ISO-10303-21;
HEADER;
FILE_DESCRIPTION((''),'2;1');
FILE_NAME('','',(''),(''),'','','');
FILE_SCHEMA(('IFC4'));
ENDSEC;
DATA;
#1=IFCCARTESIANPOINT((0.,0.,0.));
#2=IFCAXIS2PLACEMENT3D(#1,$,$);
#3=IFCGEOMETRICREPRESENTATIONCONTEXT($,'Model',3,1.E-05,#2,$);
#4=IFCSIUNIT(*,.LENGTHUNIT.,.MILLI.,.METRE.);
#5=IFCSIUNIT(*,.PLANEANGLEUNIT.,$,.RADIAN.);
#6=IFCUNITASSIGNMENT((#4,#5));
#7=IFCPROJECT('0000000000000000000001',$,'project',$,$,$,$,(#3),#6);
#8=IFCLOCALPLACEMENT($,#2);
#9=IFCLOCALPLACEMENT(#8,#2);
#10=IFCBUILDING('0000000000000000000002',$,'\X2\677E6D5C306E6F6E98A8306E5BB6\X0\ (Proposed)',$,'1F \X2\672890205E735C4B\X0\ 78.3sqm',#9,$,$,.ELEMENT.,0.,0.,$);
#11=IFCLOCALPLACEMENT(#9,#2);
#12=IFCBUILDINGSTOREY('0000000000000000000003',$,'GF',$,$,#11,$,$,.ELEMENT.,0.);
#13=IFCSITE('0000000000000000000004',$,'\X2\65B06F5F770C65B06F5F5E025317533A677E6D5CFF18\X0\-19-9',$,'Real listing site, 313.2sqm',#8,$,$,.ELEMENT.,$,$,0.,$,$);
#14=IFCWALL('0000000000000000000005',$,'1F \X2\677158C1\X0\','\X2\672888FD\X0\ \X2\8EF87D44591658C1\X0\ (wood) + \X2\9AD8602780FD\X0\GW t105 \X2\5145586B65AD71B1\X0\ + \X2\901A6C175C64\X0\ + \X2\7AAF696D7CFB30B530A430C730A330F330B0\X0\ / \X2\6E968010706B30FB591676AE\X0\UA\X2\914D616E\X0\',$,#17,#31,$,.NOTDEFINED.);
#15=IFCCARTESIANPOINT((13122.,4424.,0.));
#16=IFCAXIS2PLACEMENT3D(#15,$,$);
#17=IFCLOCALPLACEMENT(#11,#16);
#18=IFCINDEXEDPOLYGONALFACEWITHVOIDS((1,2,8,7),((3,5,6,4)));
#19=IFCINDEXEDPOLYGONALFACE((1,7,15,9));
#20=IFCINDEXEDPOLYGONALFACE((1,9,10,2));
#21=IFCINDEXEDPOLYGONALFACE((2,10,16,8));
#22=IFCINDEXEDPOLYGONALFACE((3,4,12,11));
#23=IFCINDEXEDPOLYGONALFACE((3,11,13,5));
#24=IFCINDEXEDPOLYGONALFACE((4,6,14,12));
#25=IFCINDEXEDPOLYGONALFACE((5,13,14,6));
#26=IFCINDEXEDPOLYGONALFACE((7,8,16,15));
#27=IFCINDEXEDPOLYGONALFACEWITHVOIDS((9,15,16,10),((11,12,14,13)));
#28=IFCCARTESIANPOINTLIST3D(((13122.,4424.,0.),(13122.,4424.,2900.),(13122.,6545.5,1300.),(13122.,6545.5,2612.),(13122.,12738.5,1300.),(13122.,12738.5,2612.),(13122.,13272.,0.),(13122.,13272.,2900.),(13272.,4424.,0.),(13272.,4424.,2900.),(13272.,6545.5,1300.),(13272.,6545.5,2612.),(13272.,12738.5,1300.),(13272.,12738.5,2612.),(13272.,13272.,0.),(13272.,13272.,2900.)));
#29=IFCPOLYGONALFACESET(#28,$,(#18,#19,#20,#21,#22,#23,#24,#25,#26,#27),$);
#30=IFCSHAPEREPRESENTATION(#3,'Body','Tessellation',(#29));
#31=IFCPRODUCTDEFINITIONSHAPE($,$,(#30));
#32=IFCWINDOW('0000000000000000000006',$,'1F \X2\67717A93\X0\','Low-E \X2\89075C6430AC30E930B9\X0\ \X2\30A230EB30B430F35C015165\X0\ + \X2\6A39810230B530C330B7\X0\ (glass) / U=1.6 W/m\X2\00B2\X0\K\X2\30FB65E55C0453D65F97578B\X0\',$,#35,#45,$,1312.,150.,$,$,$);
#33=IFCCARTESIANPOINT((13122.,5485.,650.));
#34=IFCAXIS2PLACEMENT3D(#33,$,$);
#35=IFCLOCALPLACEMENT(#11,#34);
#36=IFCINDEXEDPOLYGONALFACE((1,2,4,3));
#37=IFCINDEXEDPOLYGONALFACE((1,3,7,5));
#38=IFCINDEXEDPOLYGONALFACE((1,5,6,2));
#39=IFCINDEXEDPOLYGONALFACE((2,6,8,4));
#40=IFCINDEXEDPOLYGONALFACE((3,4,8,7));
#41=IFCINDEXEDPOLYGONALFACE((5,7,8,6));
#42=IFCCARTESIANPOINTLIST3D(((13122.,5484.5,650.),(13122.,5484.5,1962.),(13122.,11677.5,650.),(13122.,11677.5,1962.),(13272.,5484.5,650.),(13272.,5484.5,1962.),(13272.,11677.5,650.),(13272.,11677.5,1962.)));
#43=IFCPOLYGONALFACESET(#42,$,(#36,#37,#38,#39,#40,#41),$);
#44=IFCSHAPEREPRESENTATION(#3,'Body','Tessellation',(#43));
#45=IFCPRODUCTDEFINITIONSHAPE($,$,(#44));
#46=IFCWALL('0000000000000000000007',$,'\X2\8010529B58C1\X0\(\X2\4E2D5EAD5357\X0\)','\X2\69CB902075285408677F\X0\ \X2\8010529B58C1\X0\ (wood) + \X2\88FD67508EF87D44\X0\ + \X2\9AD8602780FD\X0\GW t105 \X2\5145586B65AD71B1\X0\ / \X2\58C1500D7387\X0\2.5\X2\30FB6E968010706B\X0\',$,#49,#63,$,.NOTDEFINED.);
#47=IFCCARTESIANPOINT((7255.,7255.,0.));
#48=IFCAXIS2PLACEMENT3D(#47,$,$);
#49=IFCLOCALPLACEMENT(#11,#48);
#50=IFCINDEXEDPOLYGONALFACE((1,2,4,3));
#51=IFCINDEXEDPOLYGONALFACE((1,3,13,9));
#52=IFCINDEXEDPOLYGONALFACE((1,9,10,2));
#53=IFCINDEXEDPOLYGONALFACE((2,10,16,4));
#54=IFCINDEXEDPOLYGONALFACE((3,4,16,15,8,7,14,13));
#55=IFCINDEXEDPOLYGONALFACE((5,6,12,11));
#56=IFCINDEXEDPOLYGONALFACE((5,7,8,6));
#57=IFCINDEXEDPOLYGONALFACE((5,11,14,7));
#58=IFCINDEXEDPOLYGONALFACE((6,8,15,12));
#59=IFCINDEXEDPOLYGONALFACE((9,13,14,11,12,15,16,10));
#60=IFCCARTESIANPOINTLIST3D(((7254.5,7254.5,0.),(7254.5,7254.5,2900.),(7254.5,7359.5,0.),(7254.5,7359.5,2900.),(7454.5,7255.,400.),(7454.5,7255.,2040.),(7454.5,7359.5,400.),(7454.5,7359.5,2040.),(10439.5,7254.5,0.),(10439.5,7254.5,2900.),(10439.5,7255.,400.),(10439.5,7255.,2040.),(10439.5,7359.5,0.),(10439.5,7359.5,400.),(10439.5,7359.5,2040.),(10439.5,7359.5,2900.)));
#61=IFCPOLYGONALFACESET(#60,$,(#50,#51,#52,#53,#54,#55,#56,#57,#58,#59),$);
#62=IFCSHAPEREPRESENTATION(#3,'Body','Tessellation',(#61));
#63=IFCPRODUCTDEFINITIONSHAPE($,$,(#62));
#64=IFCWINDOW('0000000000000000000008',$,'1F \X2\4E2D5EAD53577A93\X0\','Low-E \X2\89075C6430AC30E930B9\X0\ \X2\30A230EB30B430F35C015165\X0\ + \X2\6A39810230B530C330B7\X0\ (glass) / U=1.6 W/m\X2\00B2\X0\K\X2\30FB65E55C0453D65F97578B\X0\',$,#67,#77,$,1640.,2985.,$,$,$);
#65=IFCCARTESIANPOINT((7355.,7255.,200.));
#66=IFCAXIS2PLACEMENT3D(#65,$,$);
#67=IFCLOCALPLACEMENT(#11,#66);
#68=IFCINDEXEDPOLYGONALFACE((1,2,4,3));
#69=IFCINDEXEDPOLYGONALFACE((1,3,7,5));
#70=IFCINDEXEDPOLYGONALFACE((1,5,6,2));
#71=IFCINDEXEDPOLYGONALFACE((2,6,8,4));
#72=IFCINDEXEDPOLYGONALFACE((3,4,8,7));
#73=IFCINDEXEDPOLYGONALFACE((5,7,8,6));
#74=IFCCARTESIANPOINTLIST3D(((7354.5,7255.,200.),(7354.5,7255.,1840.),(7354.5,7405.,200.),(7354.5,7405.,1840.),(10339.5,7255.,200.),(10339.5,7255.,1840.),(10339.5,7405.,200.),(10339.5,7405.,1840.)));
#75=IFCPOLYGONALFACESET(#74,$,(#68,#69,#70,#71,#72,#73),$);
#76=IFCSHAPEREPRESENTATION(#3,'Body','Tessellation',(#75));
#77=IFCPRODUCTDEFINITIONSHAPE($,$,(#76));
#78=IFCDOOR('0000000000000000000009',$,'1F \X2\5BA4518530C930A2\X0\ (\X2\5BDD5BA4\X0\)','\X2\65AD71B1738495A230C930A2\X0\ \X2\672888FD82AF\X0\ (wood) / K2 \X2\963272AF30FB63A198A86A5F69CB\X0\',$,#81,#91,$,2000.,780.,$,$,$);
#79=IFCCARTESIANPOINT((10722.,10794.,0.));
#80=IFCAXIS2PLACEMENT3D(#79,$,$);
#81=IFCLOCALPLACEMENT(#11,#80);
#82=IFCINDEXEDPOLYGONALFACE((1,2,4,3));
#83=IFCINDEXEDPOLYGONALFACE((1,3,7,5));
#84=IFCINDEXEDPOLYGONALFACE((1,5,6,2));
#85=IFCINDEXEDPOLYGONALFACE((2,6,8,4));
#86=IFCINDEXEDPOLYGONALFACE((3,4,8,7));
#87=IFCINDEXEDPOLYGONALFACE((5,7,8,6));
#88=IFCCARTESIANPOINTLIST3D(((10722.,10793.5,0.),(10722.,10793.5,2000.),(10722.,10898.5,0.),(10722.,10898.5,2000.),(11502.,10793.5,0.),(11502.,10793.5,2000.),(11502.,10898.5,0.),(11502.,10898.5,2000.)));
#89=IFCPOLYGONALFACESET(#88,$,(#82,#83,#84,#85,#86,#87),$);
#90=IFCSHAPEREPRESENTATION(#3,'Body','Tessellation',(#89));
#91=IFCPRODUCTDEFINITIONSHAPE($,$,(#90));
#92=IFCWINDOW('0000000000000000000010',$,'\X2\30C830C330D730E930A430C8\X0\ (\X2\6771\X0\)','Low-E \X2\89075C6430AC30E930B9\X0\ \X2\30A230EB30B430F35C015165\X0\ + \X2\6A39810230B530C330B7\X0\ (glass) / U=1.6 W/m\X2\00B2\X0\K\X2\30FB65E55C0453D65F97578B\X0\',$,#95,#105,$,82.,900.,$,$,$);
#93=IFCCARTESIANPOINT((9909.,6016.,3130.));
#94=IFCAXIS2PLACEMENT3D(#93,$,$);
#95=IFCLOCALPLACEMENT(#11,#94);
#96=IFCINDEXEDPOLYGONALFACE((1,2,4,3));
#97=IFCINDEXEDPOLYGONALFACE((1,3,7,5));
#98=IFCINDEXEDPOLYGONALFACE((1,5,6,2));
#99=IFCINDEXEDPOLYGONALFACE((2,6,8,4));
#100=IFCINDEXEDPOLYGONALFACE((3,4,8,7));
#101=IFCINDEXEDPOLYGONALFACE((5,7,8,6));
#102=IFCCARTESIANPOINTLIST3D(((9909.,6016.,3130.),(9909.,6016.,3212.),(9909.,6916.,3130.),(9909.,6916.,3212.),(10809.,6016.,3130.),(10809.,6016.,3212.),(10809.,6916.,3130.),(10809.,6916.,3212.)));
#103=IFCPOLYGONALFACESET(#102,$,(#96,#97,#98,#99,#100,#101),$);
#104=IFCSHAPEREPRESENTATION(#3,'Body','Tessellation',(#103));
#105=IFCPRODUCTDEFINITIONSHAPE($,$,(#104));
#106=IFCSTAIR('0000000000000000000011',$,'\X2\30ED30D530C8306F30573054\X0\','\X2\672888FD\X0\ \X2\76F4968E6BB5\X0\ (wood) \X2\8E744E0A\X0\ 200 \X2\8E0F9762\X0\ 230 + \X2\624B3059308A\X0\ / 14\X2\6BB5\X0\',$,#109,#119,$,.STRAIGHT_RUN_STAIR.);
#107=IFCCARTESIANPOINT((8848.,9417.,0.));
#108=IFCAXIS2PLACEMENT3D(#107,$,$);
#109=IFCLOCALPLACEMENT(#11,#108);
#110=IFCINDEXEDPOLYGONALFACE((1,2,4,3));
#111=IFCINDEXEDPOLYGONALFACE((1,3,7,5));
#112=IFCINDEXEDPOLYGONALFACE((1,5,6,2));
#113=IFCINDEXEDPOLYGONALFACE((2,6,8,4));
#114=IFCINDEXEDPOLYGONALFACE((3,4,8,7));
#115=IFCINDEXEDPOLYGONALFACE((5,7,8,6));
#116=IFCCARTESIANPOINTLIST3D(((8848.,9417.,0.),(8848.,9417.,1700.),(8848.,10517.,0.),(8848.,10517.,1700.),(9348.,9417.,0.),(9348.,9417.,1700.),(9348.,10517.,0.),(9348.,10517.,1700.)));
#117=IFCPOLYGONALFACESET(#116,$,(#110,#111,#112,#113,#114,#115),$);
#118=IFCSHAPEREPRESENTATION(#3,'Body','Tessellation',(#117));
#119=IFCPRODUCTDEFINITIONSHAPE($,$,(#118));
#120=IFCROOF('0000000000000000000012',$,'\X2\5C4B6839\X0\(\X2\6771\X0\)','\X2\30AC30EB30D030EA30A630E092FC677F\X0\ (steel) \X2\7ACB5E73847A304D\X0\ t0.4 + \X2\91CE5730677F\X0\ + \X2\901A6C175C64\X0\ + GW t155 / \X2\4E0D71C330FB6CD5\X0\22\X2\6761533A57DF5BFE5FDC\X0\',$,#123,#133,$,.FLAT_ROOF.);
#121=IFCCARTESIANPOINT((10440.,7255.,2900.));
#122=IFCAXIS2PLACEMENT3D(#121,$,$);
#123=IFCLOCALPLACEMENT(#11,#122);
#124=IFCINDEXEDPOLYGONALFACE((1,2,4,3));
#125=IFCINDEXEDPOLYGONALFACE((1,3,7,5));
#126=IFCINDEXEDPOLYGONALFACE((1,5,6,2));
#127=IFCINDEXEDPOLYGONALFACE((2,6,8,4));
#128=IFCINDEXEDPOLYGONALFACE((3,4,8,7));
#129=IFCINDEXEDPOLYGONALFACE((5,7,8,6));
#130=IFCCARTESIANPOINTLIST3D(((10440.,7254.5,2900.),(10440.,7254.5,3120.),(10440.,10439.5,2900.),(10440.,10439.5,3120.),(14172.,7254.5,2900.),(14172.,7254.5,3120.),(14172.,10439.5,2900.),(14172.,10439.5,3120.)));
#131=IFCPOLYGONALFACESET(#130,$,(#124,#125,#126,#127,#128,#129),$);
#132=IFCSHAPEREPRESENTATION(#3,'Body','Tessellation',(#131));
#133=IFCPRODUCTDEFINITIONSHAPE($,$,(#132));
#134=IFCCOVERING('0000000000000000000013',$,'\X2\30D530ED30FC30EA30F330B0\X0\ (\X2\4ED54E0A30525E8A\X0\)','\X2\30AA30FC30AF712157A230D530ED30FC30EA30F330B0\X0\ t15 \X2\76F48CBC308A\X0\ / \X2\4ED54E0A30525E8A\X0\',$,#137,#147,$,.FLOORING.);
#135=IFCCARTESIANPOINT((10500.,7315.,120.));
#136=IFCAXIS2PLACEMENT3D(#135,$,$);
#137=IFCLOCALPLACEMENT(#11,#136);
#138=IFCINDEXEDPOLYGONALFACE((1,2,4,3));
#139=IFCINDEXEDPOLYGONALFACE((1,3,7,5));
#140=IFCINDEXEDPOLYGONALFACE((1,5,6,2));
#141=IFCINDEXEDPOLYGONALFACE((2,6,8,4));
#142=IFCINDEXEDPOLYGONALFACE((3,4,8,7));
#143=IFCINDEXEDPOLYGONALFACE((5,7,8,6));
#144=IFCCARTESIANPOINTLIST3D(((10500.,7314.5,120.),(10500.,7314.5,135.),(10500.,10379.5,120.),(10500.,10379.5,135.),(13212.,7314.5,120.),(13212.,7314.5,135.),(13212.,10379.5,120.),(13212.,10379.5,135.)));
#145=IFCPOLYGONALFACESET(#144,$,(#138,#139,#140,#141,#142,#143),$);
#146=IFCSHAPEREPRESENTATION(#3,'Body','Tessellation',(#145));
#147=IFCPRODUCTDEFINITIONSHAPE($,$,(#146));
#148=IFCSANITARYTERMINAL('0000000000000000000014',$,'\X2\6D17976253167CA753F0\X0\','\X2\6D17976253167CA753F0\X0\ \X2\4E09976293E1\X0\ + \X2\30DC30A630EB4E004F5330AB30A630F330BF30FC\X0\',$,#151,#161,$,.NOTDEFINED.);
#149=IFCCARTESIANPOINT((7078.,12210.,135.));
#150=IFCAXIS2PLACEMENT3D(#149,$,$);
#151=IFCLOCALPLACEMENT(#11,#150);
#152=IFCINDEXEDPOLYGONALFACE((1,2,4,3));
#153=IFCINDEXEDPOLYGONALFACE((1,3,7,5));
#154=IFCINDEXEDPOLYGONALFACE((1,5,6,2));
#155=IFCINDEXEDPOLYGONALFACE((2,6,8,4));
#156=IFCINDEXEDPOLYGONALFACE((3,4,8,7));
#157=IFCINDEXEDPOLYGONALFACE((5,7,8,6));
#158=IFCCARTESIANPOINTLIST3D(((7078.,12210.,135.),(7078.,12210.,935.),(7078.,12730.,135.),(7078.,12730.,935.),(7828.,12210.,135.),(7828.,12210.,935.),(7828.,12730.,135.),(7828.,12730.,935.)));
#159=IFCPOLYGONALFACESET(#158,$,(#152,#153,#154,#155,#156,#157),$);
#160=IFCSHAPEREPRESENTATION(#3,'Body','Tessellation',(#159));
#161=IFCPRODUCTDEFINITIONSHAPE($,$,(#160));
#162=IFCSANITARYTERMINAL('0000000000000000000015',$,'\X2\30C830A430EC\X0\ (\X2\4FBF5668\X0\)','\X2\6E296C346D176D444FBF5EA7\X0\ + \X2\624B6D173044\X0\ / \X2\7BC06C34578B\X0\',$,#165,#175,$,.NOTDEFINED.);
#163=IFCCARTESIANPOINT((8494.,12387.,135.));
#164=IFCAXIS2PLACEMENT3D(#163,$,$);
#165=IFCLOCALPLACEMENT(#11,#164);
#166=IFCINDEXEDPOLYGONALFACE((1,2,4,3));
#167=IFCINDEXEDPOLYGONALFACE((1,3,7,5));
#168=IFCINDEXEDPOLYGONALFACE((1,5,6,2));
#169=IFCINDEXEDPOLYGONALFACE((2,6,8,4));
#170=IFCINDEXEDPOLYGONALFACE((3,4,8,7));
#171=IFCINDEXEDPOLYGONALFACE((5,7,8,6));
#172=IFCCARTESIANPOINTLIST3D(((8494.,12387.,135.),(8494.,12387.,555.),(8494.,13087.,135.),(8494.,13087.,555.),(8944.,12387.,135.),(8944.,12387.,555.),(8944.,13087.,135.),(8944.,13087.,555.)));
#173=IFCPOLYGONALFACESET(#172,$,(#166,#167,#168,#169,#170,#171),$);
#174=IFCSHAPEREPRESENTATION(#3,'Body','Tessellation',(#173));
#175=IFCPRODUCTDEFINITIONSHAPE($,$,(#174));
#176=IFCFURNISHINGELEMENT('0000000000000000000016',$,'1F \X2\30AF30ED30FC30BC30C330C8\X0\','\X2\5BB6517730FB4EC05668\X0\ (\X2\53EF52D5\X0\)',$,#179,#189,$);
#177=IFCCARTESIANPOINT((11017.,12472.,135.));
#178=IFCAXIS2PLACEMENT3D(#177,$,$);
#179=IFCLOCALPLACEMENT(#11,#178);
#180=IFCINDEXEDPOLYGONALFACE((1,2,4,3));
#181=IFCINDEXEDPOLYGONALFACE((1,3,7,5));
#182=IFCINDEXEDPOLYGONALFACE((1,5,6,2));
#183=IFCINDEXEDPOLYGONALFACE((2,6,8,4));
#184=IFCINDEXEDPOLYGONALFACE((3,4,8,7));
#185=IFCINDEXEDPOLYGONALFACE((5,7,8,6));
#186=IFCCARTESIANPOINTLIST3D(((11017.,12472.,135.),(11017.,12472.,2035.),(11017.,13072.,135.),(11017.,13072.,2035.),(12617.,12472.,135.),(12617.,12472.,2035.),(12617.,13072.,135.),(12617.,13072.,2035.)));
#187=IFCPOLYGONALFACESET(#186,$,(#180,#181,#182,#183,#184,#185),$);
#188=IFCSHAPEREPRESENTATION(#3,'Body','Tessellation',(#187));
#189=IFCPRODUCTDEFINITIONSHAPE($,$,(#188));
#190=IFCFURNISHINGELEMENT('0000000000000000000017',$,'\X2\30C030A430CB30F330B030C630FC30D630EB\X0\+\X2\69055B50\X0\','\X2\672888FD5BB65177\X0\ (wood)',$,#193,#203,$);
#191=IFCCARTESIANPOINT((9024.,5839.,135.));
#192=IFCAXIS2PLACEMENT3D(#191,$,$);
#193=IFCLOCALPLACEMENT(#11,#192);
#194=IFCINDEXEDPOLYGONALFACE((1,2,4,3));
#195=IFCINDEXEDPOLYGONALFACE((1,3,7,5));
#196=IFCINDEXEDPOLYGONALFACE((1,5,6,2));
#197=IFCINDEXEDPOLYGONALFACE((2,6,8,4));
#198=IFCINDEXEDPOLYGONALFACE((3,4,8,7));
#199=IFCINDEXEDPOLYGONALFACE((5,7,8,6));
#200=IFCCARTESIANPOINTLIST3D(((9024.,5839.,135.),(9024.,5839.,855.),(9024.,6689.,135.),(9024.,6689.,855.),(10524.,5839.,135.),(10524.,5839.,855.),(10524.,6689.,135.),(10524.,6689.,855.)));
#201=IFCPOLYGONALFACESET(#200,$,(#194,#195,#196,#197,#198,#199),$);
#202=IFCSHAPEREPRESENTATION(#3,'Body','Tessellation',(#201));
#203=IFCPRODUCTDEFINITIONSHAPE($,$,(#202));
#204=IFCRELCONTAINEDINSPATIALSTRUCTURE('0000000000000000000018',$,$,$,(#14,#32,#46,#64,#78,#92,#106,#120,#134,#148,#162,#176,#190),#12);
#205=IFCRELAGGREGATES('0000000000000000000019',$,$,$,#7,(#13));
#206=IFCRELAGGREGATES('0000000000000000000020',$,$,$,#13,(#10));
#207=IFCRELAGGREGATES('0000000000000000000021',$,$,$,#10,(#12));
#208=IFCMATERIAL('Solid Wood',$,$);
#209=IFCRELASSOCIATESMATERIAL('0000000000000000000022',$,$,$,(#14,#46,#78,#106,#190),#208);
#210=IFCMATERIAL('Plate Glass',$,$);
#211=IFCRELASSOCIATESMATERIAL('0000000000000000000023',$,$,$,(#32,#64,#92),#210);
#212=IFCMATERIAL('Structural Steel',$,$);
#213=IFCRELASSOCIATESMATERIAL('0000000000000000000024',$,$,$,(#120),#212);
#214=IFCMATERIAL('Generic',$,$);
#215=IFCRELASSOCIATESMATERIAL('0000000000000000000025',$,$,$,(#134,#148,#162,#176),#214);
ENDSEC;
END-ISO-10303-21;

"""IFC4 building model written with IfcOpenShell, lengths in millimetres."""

from ifc_helpers import new_model, si_unit, frame, frame_2d, origin, place, context, project, spatial, rectangle, extrude, material, element, fill, save


model = new_model("IFC4")

# Units and contexts
model_context = context("Model", 3, precision=1e-05, world=origin())
ifc_project = project(units=[si_unit("LENGTHUNIT", "METRE", prefix="MILLI"), si_unit("PLANEANGLEUNIT", "RADIAN")], contexts=[model_context])

# Site, building, storey
site_placement = place(None, origin())
site = spatial("IfcSite", under=ifc_project, at=site_placement, Name="新潟県新潟市北区松浜８-19-9", ObjectType="Real listing site, 313.2sqm", CompositionType="ELEMENT", RefElevation=0.0)
building_placement = place(site_placement, origin())
building = spatial("IfcBuilding", under=site, at=building_placement, Name="松浜の潮風の家 (Proposed)", ObjectType="1F 木造平屋 78.3sqm", CompositionType="ELEMENT", ElevationOfRefHeight=0.0, ElevationOfTerrain=0.0)
storey_placement = place(building_placement, origin())
storey = spatial("IfcBuildingStorey", under=building, at=storey_placement, Name="GF", CompositionType="ELEMENT", Elevation=0.0)

# Shared definitions
ifc_material_1 = material(Name="Solid Wood")

# Walls, openings, windows
wall_1_placement = place(storey_placement, frame((13122.0, 4424.0, 0.0)))
wall_1 = element("IfcWall", 1, at=wall_1_placement, inside=storey, material=ifc_material_1, Name="1F 東壁", Description="木製 軸組外壁 (wood) + 高性能GW t105 充填断熱 + 通気層 + 窯業系サイディング / 準耐火・外皮UA配慮", PredefinedType="NOTDEFINED", context=model_context, shape_type="SweptSolid", body=[
    extrude(rectangle(XDim=150.0, YDim=8848.0, at=frame_2d((75.0, 4424.0))), frame((13122.0, 4424.0, 0.0)), (0.0, 0.0, 1.0), 2900.0),
])
opening_1_placement = place(storey_placement, frame((13122.0, 5485.0, 650.0)))
opening_1 = element("IfcOpeningElement", 2, at=opening_1_placement, cuts=wall_1, PredefinedType="NOTDEFINED", context=model_context, shape_type="SweptSolid", body=[
    extrude(rectangle(XDim=150.0, YDim=6193.0, at=frame_2d((75.0, 3096.0))), frame((13122.0, 5485.0, 650.0)), (0.0, 0.0, 1.0), 1312.0),
])
ifc_material_2 = material(Name="Plate Glass")
window_1_placement = place(storey_placement, frame((13122.0, 5485.0, 650.0)))
window_1 = element("IfcWindow", 3, at=window_1_placement, inside=storey, material=ifc_material_2, Name="1F 東窓", Description="Low-E 複層ガラス アルゴン封入 + 樹脂サッシ (glass) / U=1.6 W/m²K・日射取得型", OverallHeight=1312.0, OverallWidth=150.0, context=model_context, shape_type="SweptSolid", body=[
    extrude(rectangle(XDim=150.0, YDim=6193.0, at=frame_2d((75.0, 3096.0))), frame((13122.0, 5485.0, 650.0)), (0.0, 0.0, 1.0), 1312.0),
])
fill(opening_1, window_1)
wall_2_placement = place(storey_placement, frame((7255.0, 7255.0, 0.0)))
wall_2 = element("IfcWall", 4, at=wall_2_placement, inside=storey, material=ifc_material_1, Name="耐力壁(中庭南)", Description="構造用合板 耐力壁 (wood) + 製材軸組 + 高性能GW t105 充填断熱 / 壁倍率2.5・準耐火", PredefinedType="NOTDEFINED", context=model_context, shape_type="SweptSolid", body=[
    extrude(rectangle(XDim=3185.0, YDim=105.0, at=frame_2d((1592.0, 52.0))), frame((7255.0, 7255.0, 0.0)), (0.0, 0.0, 1.0), 2900.0),
])
opening_2_placement = place(storey_placement, frame((7355.0, 7255.0, 200.0)))
opening_2 = element("IfcOpeningElement", 5, at=opening_2_placement, cuts=wall_2, PredefinedType="NOTDEFINED", context=model_context, shape_type="SweptSolid", body=[
    extrude(rectangle(XDim=2985.0, YDim=150.0, at=frame_2d((1492.0, 75.0))), frame((7355.0, 7255.0, 200.0)), (0.0, 0.0, 1.0), 1640.0),
])
window_2_placement = place(storey_placement, frame((7355.0, 7255.0, 200.0)))
window_2 = element("IfcWindow", 6, at=window_2_placement, inside=storey, material=ifc_material_2, Name="1F 中庭南窓", Description="Low-E 複層ガラス アルゴン封入 + 樹脂サッシ (glass) / U=1.6 W/m²K・日射取得型", OverallHeight=1640.0, OverallWidth=2985.0, context=model_context, shape_type="SweptSolid", body=[
    extrude(rectangle(XDim=2985.0, YDim=150.0, at=frame_2d((1492.0, 75.0))), frame((7355.0, 7255.0, 200.0)), (0.0, 0.0, 1.0), 1640.0),
])
fill(opening_2, window_2)

# Door
door_placement = place(storey_placement, frame((10722.0, 10794.0, 0.0)))
element("IfcDoor", 7, at=door_placement, inside=storey, material=ifc_material_1, Name="1F 室内ドア (寝室)", Description="断熱玄関ドア 木製芯 (wood) / K2 防犯・採風機構", OverallHeight=2000.0, OverallWidth=780.0, context=model_context, shape_type="SweptSolid", body=[
    extrude(rectangle(XDim=780.0, YDim=105.0, at=frame_2d((390.0, 52.0))), frame((10722.0, 10794.0, 0.0)), (0.0, 0.0, 1.0), 2000.0),
])

# Window
window_3_placement = place(storey_placement, frame((9909.0, 6016.0, 3130.0)))
element("IfcWindow", 8, at=window_3_placement, inside=storey, material=ifc_material_2, Name="トップライト (東)", Description="Low-E 複層ガラス アルゴン封入 + 樹脂サッシ (glass) / U=1.6 W/m²K・日射取得型", OverallHeight=82.0, OverallWidth=900.0, context=model_context, shape_type="SweptSolid", body=[
    extrude(rectangle(XDim=900.0, YDim=900.0, at=frame_2d((450.0, 450.0))), frame((9909.0, 6016.0, 3130.0)), (0.0, 0.0, 1.0), 82.0),
])

# Stair
stair_placement = place(storey_placement, frame((8848.0, 9417.0, 0.0)))
element("IfcStair", 9, at=stair_placement, inside=storey, material=ifc_material_1, Name="ロフトはしご", Description="木製 直階段 (wood) 蹴上 200 踏面 230 + 手すり / 14段", PredefinedType="STRAIGHT_RUN_STAIR", context=model_context, shape_type="SweptSolid", body=[
    extrude(rectangle(XDim=500.0, YDim=1100.0, at=frame_2d((250.0, 550.0))), frame((8848.0, 9417.0, 0.0)), (0.0, 0.0, 1.0), 1700.0),
])

# Roof
ifc_material_3 = material(Name="Structural Steel")
roof_placement = place(storey_placement, frame((10440.0, 7255.0, 2900.0)))
element("IfcRoof", 10, at=roof_placement, inside=storey, material=ifc_material_3, Name="屋根(東)", Description="ガルバリウム鋼板 (steel) 立平葺き t0.4 + 野地板 + 通気層 + GW t155 / 不燃・法22条区域対応", PredefinedType="FLAT_ROOF", context=model_context, shape_type="SweptSolid", body=[
    extrude(rectangle(XDim=3732.0, YDim=3185.0, at=frame_2d((1866.0, 1592.0))), frame((10440.0, 7255.0, 2900.0)), (0.0, 0.0, 1.0), 220.0),
])

# Covering
ifc_material_4 = material(Name="Generic")
covering_placement = place(storey_placement, frame((10500.0, 7315.0, 120.0)))
element("IfcCovering", 11, at=covering_placement, inside=storey, material=ifc_material_4, Name="フローリング (仕上げ床)", Description="オーク無垢フローリング t15 直貼り / 仕上げ床", PredefinedType="FLOORING", context=model_context, shape_type="SweptSolid", body=[
    extrude(rectangle(XDim=2712.0, YDim=3065.0, at=frame_2d((1356.0, 1532.0))), frame((10500.0, 7315.0, 120.0)), (0.0, 0.0, 1.0), 15.0),
])

# Sanitary terminals
sanitary_terminal_1_placement = place(storey_placement, frame((7078.0, 12210.0, 135.0)))
element("IfcSanitaryTerminal", 12, at=sanitary_terminal_1_placement, inside=storey, material=ifc_material_4, Name="洗面化粧台", Description="洗面化粧台 三面鏡 + ボウル一体カウンター", PredefinedType="NOTDEFINED", context=model_context, shape_type="SweptSolid", body=[
    extrude(rectangle(XDim=750.0, YDim=520.0, at=frame_2d((375.0, 260.0))), frame((7078.0, 12210.0, 135.0)), (0.0, 0.0, 1.0), 800.0),
])
sanitary_terminal_2_placement = place(storey_placement, frame((8494.0, 12387.0, 135.0)))
element("IfcSanitaryTerminal", 13, at=sanitary_terminal_2_placement, inside=storey, material=ifc_material_4, Name="トイレ (便器)", Description="温水洗浄便座 + 手洗い / 節水型", PredefinedType="NOTDEFINED", context=model_context, shape_type="SweptSolid", body=[
    extrude(rectangle(XDim=450.0, YDim=700.0, at=frame_2d((225.0, 350.0))), frame((8494.0, 12387.0, 135.0)), (0.0, 0.0, 1.0), 420.0),
])

# Furnishing elements
furnishing_1_placement = place(storey_placement, frame((11017.0, 12472.0, 135.0)))
element("IfcFurnishingElement", 14, at=furnishing_1_placement, inside=storey, material=ifc_material_4, Name="1F クローゼット", Description="家具・什器 (可動)", context=model_context, shape_type="SweptSolid", body=[
    extrude(rectangle(XDim=1600.0, YDim=600.0, at=frame_2d((800.0, 300.0))), frame((11017.0, 12472.0, 135.0)), (0.0, 0.0, 1.0), 1900.0),
])
furnishing_2_placement = place(storey_placement, frame((9024.0, 5839.0, 135.0)))
element("IfcFurnishingElement", 15, at=furnishing_2_placement, inside=storey, material=ifc_material_1, Name="ダイニングテーブル+椅子", Description="木製家具 (wood)", context=model_context, shape_type="SweptSolid", body=[
    extrude(rectangle(XDim=1500.0, YDim=850.0, at=frame_2d((750.0, 425.0))), frame((9024.0, 5839.0, 135.0)), (0.0, 0.0, 1.0), 720.0),
])

save(model, "model.ifc")
